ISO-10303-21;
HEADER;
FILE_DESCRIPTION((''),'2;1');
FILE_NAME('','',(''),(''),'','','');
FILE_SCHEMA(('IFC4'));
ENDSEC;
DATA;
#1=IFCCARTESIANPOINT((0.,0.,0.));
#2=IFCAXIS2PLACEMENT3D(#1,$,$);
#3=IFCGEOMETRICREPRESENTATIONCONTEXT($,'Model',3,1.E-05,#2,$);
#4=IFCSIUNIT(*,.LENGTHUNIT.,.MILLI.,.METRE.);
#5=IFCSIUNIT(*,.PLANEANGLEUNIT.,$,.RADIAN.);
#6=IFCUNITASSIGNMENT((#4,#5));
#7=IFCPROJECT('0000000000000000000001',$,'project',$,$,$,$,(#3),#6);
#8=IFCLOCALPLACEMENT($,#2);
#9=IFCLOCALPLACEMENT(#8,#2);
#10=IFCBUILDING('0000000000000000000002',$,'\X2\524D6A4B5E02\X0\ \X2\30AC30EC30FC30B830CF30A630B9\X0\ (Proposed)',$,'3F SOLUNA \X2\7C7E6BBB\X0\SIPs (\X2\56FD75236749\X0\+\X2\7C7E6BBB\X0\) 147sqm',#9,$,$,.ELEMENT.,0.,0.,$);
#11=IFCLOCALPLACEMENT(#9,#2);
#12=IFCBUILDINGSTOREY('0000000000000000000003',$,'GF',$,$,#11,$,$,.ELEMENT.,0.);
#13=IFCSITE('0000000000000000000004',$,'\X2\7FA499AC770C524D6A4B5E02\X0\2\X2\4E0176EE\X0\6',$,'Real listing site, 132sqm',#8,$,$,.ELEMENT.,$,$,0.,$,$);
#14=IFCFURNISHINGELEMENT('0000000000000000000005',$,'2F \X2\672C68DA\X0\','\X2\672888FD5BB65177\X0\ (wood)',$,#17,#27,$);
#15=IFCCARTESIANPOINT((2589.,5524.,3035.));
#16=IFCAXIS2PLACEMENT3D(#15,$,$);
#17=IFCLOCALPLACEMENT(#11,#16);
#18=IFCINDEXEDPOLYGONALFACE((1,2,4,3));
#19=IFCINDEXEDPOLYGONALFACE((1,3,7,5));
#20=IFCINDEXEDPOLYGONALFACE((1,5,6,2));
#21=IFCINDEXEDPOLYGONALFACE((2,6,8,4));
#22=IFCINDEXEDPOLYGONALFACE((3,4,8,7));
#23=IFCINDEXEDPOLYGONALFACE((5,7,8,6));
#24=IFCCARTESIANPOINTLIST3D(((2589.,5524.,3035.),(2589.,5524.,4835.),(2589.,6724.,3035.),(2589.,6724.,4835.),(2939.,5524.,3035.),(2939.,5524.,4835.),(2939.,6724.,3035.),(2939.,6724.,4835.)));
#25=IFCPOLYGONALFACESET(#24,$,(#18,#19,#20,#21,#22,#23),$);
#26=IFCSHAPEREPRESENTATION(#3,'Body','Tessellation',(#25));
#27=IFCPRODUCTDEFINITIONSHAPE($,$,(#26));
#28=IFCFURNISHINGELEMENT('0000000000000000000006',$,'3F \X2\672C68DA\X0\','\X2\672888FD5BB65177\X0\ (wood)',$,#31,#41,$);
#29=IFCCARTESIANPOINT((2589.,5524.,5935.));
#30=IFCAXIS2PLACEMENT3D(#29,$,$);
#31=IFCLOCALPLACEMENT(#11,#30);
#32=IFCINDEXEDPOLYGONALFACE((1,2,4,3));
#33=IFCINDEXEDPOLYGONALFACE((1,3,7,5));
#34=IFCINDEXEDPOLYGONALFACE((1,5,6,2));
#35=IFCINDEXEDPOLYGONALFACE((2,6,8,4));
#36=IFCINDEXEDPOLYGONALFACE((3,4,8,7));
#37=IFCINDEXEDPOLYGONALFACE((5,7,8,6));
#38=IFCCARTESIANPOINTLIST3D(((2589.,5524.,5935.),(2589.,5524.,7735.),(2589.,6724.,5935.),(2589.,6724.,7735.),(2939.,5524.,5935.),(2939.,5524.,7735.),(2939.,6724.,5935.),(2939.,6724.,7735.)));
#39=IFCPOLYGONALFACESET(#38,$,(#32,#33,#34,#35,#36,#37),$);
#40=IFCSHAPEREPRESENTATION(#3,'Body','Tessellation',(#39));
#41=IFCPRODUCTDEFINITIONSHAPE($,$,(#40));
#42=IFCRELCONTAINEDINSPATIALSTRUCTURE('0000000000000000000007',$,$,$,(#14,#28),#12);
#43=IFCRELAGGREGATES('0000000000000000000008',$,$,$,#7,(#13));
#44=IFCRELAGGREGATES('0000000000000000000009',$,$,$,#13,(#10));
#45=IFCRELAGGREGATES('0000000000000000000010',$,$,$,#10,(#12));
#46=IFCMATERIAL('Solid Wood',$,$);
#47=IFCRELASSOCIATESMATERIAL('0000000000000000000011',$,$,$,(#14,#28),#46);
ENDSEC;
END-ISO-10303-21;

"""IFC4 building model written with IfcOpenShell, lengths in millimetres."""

from ifc_helpers import new_model, si_unit, frame, frame_2d, origin, place, context, project, spatial, rectangle, extrude, material, element, save


model = new_model("IFC4")

# Units and contexts
model_context = context("Model", 3, precision=1e-05, world=origin())
ifc_project = project(units=[si_unit("LENGTHUNIT", "METRE", prefix="MILLI"), si_unit("PLANEANGLEUNIT", "RADIAN")], contexts=[model_context])

# Site, building, storey
site_placement = place(None, origin())
site = spatial("IfcSite", under=ifc_project, at=site_placement, Name="群馬県前橋市2丁目6", ObjectType="Real listing site, 132sqm", CompositionType="ELEMENT", RefElevation=0.0)
building_placement = place(site_placement, origin())
building = spatial("IfcBuilding", under=site, at=building_placement, Name="前橋市 ガレージハウス (Proposed)", ObjectType="3F SOLUNA 籾殻SIPs (国産杉+籾殻) 147sqm", CompositionType="ELEMENT", ElevationOfRefHeight=0.0, ElevationOfTerrain=0.0)
storey_placement = place(building_placement, origin())
storey = spatial("IfcBuildingStorey", under=building, at=storey_placement, Name="GF", CompositionType="ELEMENT", Elevation=0.0)

# Shared definitions
ifc_material_1 = material(Name="Solid Wood")

# Furnishing elements
furnishing_1_placement = place(storey_placement, frame((2589.0, 5524.0, 3035.0)))
element("IfcFurnishingElement", 1, at=furnishing_1_placement, inside=storey, material=ifc_material_1, Name="2F 本棚", Description="木製家具 (wood)", context=model_context, shape_type="SweptSolid", body=[
    extrude(rectangle(XDim=350.0, YDim=1200.0, at=frame_2d((175.0, 600.0))), frame((2589.0, 5524.0, 3035.0)), (0.0, 0.0, 1.0), 1800.0),
])
furnishing_2_placement = place(storey_placement, frame((2589.0, 5524.0, 5935.0)))
element("IfcFurnishingElement", 2, at=furnishing_2_placement, inside=storey, material=ifc_material_1, Name="3F 本棚", Description="木製家具 (wood)", context=model_context, shape_type="SweptSolid", body=[
    extrude(rectangle(XDim=350.0, YDim=1200.0, at=frame_2d((175.0, 600.0))), frame((2589.0, 5524.0, 5935.0)), (0.0, 0.0, 1.0), 1800.0),
])

save(model, "model.ifc")
